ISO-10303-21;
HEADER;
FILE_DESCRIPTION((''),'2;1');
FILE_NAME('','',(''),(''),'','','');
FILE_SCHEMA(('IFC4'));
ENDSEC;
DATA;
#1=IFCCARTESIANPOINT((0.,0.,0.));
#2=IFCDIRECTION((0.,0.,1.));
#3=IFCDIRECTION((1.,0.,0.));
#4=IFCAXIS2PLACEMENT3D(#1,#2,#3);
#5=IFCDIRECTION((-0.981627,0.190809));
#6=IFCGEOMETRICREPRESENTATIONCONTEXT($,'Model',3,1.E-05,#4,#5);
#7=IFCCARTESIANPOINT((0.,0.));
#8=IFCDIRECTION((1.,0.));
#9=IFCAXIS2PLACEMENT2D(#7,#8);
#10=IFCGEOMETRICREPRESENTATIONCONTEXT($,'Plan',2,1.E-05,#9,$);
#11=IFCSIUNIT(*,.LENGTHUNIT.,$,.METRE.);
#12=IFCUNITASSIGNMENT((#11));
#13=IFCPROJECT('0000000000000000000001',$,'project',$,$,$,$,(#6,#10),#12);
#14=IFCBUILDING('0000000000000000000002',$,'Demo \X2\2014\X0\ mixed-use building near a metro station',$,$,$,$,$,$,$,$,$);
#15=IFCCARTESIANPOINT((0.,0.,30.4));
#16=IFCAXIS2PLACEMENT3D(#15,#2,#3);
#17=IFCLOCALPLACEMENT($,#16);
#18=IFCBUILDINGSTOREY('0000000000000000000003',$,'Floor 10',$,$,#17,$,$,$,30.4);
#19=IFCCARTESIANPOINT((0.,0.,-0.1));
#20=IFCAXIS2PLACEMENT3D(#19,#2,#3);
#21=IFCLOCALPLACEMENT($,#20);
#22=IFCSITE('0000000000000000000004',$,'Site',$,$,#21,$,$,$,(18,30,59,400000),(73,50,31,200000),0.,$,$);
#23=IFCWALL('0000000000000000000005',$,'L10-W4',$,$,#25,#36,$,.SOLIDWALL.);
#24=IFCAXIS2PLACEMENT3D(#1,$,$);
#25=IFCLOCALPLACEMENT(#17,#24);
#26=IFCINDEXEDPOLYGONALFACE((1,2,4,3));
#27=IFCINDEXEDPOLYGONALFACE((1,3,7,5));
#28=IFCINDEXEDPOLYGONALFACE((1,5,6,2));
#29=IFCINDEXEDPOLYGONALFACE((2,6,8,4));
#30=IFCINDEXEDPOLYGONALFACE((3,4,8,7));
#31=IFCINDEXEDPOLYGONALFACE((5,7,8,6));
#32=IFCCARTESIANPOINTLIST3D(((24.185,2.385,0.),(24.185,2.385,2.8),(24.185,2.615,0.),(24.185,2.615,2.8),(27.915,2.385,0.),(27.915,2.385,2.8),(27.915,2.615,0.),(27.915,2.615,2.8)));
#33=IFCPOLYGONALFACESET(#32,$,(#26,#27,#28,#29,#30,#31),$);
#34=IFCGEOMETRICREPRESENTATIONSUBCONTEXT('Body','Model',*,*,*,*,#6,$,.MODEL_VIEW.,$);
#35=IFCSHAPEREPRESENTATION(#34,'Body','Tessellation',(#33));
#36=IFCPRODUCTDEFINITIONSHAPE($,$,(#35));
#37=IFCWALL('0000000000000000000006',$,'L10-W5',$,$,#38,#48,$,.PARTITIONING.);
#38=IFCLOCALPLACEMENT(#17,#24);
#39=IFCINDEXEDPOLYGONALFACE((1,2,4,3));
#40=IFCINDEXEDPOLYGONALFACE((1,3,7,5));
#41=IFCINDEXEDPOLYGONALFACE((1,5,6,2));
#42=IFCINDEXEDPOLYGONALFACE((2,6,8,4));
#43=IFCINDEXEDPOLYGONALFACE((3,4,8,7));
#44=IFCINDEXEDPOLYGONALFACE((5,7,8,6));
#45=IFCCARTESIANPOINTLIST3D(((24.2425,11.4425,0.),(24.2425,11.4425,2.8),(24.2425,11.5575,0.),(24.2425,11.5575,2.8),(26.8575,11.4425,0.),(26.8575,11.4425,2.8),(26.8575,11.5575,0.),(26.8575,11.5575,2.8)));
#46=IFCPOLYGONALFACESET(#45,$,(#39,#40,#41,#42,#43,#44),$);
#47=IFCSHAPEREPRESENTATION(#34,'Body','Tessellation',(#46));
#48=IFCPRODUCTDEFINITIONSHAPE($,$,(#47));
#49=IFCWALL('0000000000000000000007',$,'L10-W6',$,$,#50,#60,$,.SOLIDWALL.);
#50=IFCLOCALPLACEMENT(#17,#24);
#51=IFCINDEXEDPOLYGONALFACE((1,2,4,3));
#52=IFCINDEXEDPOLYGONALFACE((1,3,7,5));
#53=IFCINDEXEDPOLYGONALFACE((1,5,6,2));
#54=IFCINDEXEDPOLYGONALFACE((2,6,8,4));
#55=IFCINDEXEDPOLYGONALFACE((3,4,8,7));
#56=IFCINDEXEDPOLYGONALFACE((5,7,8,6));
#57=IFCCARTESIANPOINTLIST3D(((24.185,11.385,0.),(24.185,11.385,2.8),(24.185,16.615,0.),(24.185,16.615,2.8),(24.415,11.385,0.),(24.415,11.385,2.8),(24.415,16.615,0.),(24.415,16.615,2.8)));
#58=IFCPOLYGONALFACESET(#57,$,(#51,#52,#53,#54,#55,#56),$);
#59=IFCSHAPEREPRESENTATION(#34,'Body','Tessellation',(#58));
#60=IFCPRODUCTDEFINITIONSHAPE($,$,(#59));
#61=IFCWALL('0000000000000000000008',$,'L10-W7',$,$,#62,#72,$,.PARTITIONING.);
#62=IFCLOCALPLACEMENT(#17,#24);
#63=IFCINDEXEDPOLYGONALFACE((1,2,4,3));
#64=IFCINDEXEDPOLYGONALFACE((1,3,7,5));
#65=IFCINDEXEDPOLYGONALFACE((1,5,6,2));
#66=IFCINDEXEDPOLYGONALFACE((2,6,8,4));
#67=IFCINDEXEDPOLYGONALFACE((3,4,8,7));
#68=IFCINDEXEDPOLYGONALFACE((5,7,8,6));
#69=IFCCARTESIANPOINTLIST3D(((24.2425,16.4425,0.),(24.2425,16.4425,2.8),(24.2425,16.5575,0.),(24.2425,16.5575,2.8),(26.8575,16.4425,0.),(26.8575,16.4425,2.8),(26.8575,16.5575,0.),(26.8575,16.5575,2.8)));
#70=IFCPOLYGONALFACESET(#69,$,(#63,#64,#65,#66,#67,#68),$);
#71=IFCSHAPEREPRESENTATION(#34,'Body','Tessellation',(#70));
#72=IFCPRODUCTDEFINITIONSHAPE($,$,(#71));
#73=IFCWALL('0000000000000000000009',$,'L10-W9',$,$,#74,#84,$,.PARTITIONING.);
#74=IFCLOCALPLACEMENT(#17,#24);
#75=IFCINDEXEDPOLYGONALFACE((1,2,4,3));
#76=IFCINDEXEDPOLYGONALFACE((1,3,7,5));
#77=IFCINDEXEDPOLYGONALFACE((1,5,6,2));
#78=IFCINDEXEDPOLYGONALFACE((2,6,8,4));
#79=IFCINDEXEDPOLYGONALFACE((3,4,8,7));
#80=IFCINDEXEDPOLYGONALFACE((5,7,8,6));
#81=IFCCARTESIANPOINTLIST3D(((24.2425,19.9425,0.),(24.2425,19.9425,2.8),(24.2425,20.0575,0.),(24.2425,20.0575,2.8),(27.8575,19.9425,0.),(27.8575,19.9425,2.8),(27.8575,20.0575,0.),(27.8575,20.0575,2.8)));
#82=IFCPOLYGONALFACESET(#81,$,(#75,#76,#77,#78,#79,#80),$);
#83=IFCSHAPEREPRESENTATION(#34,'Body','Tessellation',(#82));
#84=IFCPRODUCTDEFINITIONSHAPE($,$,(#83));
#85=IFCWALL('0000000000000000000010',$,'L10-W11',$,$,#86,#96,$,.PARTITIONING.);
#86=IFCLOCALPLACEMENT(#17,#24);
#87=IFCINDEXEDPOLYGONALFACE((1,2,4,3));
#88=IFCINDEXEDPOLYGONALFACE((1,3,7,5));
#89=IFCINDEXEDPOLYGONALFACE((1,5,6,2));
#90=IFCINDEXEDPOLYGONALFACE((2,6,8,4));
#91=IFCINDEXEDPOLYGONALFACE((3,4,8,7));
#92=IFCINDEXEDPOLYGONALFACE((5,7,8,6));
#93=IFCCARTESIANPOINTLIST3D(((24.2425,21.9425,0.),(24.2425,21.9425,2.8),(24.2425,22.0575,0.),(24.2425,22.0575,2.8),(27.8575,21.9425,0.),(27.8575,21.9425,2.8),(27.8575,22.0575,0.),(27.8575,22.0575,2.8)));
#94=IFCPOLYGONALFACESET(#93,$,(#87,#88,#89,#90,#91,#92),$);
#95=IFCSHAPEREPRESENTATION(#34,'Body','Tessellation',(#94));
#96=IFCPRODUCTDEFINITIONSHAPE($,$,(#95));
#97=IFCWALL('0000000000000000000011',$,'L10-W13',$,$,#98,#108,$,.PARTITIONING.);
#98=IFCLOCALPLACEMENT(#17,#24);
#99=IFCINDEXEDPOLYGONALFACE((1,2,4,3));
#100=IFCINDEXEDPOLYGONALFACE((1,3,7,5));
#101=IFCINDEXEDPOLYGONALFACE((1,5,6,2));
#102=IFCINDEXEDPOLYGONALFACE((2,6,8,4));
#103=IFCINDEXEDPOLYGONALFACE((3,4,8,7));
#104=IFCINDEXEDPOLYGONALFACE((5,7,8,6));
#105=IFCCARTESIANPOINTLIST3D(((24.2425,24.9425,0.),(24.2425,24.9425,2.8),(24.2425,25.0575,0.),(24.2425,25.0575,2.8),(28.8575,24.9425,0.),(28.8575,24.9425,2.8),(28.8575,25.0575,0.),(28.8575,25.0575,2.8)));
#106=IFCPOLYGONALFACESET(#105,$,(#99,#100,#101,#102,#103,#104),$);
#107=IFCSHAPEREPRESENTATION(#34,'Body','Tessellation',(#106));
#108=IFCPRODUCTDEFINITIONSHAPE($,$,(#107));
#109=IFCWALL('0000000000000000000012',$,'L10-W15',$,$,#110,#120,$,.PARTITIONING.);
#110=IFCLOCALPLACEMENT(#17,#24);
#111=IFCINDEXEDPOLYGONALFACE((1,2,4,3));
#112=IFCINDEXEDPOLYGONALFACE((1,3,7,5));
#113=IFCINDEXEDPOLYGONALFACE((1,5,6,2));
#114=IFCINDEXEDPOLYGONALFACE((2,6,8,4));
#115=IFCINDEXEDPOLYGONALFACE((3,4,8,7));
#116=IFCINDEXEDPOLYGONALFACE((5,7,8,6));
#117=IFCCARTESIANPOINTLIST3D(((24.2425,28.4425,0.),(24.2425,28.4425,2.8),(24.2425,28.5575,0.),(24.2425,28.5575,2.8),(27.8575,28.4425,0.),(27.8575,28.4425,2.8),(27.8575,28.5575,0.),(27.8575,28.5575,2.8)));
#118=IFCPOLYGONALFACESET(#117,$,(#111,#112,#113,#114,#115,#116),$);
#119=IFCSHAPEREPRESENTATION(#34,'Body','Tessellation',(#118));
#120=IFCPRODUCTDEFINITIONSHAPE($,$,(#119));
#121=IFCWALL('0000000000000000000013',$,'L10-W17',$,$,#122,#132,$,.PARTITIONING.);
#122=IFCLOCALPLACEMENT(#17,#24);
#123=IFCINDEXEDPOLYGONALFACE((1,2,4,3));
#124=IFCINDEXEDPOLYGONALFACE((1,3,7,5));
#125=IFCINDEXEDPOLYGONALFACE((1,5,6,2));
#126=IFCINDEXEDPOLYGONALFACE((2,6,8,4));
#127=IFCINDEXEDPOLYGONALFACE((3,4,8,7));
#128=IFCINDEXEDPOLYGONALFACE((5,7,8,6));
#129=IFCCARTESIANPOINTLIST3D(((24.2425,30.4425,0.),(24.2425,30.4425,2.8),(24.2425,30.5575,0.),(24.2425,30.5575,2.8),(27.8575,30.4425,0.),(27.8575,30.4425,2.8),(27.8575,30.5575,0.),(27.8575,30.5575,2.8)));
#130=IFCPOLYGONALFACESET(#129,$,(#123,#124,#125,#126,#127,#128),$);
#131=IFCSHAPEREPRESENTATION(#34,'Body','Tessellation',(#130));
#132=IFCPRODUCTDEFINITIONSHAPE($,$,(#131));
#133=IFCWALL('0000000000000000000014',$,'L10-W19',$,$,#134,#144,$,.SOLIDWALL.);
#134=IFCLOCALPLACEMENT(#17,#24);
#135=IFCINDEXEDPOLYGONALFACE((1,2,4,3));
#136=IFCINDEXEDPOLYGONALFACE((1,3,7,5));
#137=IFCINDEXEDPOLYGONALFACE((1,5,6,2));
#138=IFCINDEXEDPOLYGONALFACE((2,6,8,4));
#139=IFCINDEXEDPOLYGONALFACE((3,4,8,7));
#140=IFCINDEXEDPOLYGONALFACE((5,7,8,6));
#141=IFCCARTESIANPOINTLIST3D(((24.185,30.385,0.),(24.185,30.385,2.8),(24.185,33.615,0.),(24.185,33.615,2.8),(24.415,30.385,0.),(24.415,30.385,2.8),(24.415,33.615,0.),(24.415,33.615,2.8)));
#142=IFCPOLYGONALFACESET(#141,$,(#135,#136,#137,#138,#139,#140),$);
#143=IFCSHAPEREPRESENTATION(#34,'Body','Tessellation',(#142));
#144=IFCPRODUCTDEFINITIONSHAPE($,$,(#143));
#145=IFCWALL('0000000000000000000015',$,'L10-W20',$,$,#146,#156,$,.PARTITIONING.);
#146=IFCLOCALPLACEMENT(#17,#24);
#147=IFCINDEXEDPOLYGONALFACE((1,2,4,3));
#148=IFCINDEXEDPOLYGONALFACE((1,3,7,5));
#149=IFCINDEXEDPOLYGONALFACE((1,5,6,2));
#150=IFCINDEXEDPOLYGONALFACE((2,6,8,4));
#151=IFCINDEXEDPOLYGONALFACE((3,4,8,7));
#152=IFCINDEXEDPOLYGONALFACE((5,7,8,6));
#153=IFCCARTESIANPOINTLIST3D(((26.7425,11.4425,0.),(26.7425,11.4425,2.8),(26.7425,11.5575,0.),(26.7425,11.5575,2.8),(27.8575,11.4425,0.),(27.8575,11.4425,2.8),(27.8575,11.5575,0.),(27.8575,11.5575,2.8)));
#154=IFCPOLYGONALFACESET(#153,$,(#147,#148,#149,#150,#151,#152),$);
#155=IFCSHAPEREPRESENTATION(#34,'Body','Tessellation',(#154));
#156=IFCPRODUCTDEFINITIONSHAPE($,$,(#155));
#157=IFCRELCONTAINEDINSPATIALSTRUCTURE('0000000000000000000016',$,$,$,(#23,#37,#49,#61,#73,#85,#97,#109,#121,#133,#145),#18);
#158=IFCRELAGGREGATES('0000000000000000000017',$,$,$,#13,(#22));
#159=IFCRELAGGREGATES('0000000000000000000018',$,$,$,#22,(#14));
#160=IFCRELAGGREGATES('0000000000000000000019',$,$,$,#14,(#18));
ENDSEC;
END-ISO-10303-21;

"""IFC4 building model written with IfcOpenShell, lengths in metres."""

from ifc_helpers import new_model, si_unit, direction, frame, origin_with_axes, origin_2d_with_axis, place, context, subcontext, project, spatial, line, indexed_curve, outline, extrude, element, save


model = new_model("IFC4")

# Units and contexts
model_context = context("Model", 3, precision=1e-05, world=origin_with_axes(), true_north=direction((-0.981627, 0.190809)))
plan_context = context("Plan", 2, precision=1e-05, world=origin_2d_with_axis())
body_context = subcontext(model_context, "Body", "Model", "MODEL_VIEW")
ifc_project = project(units=[si_unit("LENGTHUNIT", "METRE")], contexts=[model_context, plan_context])

# Site, building, storey
site_placement = place(None, frame((0.0, 0.0, -0.1), z_axis=(0.0, 0.0, 1.0), x_axis=(1.0, 0.0, 0.0)))
site = spatial("IfcSite", under=ifc_project, at=site_placement, Name="Site", RefLatitude=(18, 30, 59, 400000), RefLongitude=(73, 50, 31, 200000), RefElevation=0.0)
building = spatial("IfcBuilding", under=site, Name="Demo — mixed-use building near a metro station")
storey_placement = place(None, frame((0.0, 0.0, 30.4), z_axis=(0.0, 0.0, 1.0), x_axis=(1.0, 0.0, 0.0)))
storey = spatial("IfcBuildingStorey", under=building, at=storey_placement, Name="Floor 10", Elevation=30.4)

# Walls
wall_1_placement = place(storey_placement, frame((0.0, 0.0, -30.4), z_axis=(0.0, 0.0, 1.0), x_axis=(1.0, 0.0, 0.0)))
element("IfcWall", 1, at=wall_1_placement, inside=storey, Name="L10-W4", PredefinedType="SOLIDWALL", context=body_context, shape_type="SweptSolid", body=[
    extrude(outline(indexed_curve([(24.185, 2.615), (27.915, 2.615), (27.915, 2.385), (24.185, 2.385)], segments=[line(1, 2, 3, 4, 1)])), frame((0.0, 0.0, 30.4), z_axis=(0.0, 0.0, 1.0), x_axis=(1.0, 0.0, 0.0)), (0.0, 0.0, 1.0), 2.8),
])
wall_2_placement = place(storey_placement, frame((0.0, 0.0, -30.4), z_axis=(0.0, 0.0, 1.0), x_axis=(1.0, 0.0, 0.0)))
element("IfcWall", 2, at=wall_2_placement, inside=storey, Name="L10-W5", PredefinedType="PARTITIONING", context=body_context, shape_type="SweptSolid", body=[
    extrude(outline(indexed_curve([(24.2425, 11.5575), (26.8575, 11.5575), (26.8575, 11.4425), (24.2425, 11.4425)], segments=[line(1, 2, 3, 4, 1)])), frame((0.0, 0.0, 30.4), z_axis=(0.0, 0.0, 1.0), x_axis=(1.0, 0.0, 0.0)), (0.0, 0.0, 1.0), 2.8),
])
wall_3_placement = place(storey_placement, frame((0.0, 0.0, -30.4), z_axis=(0.0, 0.0, 1.0), x_axis=(1.0, 0.0, 0.0)))
element("IfcWall", 3, at=wall_3_placement, inside=storey, Name="L10-W6", PredefinedType="SOLIDWALL", context=body_context, shape_type="SweptSolid", body=[
    extrude(outline(indexed_curve([(24.415, 16.615), (24.415, 11.385), (24.185, 11.385), (24.185, 16.615)], segments=[line(1, 2, 3, 4, 1)])), frame((0.0, 0.0, 30.4), z_axis=(0.0, 0.0, 1.0), x_axis=(1.0, 0.0, 0.0)), (0.0, 0.0, 1.0), 2.8),
])
wall_4_placement = place(storey_placement, frame((0.0, 0.0, -30.4), z_axis=(0.0, 0.0, 1.0), x_axis=(1.0, 0.0, 0.0)))
element("IfcWall", 4, at=wall_4_placement, inside=storey, Name="L10-W7", PredefinedType="PARTITIONING", context=body_context, shape_type="SweptSolid", body=[
    extrude(outline(indexed_curve([(26.8575, 16.4425), (24.2425, 16.4425), (24.2425, 16.5575), (26.8575, 16.5575)], segments=[line(1, 2, 3, 4, 1)])), frame((0.0, 0.0, 30.4), z_axis=(0.0, 0.0, 1.0), x_axis=(1.0, 0.0, 0.0)), (0.0, 0.0, 1.0), 2.8),
])

# Wall
wall_5_placement = place(storey_placement, frame((0.0, 0.0, -30.4), z_axis=(0.0, 0.0, 1.0), x_axis=(1.0, 0.0, 0.0)))
element("IfcWall", 5, at=wall_5_placement, inside=storey, Name="L10-W9", PredefinedType="PARTITIONING", context=body_context, shape_type="SweptSolid", body=[
    extrude(outline(indexed_curve([(27.8575, 19.9425), (24.2425, 19.9425), (24.2425, 20.0575), (27.8575, 20.0575)], segments=[line(1, 2, 3, 4, 1)])), frame((0.0, 0.0, 30.4), z_axis=(0.0, 0.0, 1.0), x_axis=(1.0, 0.0, 0.0)), (0.0, 0.0, 1.0), 2.8),
])

# Wall
wall_6_placement = place(storey_placement, frame((0.0, 0.0, -30.4), z_axis=(0.0, 0.0, 1.0), x_axis=(1.0, 0.0, 0.0)))
element("IfcWall", 6, at=wall_6_placement, inside=storey, Name="L10-W11", PredefinedType="PARTITIONING", context=body_context, shape_type="SweptSolid", body=[
    extrude(outline(indexed_curve([(27.8575, 21.9425), (24.2425, 21.9425), (24.2425, 22.0575), (27.8575, 22.0575)], segments=[line(1, 2, 3, 4, 1)])), frame((0.0, 0.0, 30.4), z_axis=(0.0, 0.0, 1.0), x_axis=(1.0, 0.0, 0.0)), (0.0, 0.0, 1.0), 2.8),
])

# Wall
wall_7_placement = place(storey_placement, frame((0.0, 0.0, -30.4), z_axis=(0.0, 0.0, 1.0), x_axis=(1.0, 0.0, 0.0)))
element("IfcWall", 7, at=wall_7_placement, inside=storey, Name="L10-W13", PredefinedType="PARTITIONING", context=body_context, shape_type="SweptSolid", body=[
    extrude(outline(indexed_curve([(28.8575, 24.9425), (24.2425, 24.9425), (24.2425, 25.0575), (28.8575, 25.0575)], segments=[line(1, 2, 3, 4, 1)])), frame((0.0, 0.0, 30.4), z_axis=(0.0, 0.0, 1.0), x_axis=(1.0, 0.0, 0.0)), (0.0, 0.0, 1.0), 2.8),
])

# Wall
wall_8_placement = place(storey_placement, frame((0.0, 0.0, -30.4), z_axis=(0.0, 0.0, 1.0), x_axis=(1.0, 0.0, 0.0)))
element("IfcWall", 8, at=wall_8_placement, inside=storey, Name="L10-W15", PredefinedType="PARTITIONING", context=body_context, shape_type="SweptSolid", body=[
    extrude(outline(indexed_curve([(27.8575, 28.4425), (24.2425, 28.4425), (24.2425, 28.5575), (27.8575, 28.5575)], segments=[line(1, 2, 3, 4, 1)])), frame((0.0, 0.0, 30.4), z_axis=(0.0, 0.0, 1.0), x_axis=(1.0, 0.0, 0.0)), (0.0, 0.0, 1.0), 2.8),
])

# Wall
wall_9_placement = place(storey_placement, frame((0.0, 0.0, -30.4), z_axis=(0.0, 0.0, 1.0), x_axis=(1.0, 0.0, 0.0)))
element("IfcWall", 9, at=wall_9_placement, inside=storey, Name="L10-W17", PredefinedType="PARTITIONING", context=body_context, shape_type="SweptSolid", body=[
    extrude(outline(indexed_curve([(27.8575, 30.4425), (24.2425, 30.4425), (24.2425, 30.5575), (27.8575, 30.5575)], segments=[line(1, 2, 3, 4, 1)])), frame((0.0, 0.0, 30.4), z_axis=(0.0, 0.0, 1.0), x_axis=(1.0, 0.0, 0.0)), (0.0, 0.0, 1.0), 2.8),
])

# Walls
wall_10_placement = place(storey_placement, frame((0.0, 0.0, -30.4), z_axis=(0.0, 0.0, 1.0), x_axis=(1.0, 0.0, 0.0)))
element("IfcWall", 10, at=wall_10_placement, inside=storey, Name="L10-W19", PredefinedType="SOLIDWALL", context=body_context, shape_type="SweptSolid", body=[
    extrude(outline(indexed_curve([(24.415, 33.615), (24.415, 30.385), (24.185, 30.385), (24.185, 33.615)], segments=[line(1, 2, 3, 4, 1)])), frame((0.0, 0.0, 30.4), z_axis=(0.0, 0.0, 1.0), x_axis=(1.0, 0.0, 0.0)), (0.0, 0.0, 1.0), 2.8),
])
wall_11_placement = place(storey_placement, frame((0.0, 0.0, -30.4), z_axis=(0.0, 0.0, 1.0), x_axis=(1.0, 0.0, 0.0)))
element("IfcWall", 11, at=wall_11_placement, inside=storey, Name="L10-W20", PredefinedType="PARTITIONING", context=body_context, shape_type="SweptSolid", body=[
    extrude(outline(indexed_curve([(26.7425, 11.5575), (27.8575, 11.5575), (27.8575, 11.4425), (26.7425, 11.4425)], segments=[line(1, 2, 3, 4, 1)])), frame((0.0, 0.0, 30.4), z_axis=(0.0, 0.0, 1.0), x_axis=(1.0, 0.0, 0.0)), (0.0, 0.0, 1.0), 2.8),
])

save(model, "model.ifc")
